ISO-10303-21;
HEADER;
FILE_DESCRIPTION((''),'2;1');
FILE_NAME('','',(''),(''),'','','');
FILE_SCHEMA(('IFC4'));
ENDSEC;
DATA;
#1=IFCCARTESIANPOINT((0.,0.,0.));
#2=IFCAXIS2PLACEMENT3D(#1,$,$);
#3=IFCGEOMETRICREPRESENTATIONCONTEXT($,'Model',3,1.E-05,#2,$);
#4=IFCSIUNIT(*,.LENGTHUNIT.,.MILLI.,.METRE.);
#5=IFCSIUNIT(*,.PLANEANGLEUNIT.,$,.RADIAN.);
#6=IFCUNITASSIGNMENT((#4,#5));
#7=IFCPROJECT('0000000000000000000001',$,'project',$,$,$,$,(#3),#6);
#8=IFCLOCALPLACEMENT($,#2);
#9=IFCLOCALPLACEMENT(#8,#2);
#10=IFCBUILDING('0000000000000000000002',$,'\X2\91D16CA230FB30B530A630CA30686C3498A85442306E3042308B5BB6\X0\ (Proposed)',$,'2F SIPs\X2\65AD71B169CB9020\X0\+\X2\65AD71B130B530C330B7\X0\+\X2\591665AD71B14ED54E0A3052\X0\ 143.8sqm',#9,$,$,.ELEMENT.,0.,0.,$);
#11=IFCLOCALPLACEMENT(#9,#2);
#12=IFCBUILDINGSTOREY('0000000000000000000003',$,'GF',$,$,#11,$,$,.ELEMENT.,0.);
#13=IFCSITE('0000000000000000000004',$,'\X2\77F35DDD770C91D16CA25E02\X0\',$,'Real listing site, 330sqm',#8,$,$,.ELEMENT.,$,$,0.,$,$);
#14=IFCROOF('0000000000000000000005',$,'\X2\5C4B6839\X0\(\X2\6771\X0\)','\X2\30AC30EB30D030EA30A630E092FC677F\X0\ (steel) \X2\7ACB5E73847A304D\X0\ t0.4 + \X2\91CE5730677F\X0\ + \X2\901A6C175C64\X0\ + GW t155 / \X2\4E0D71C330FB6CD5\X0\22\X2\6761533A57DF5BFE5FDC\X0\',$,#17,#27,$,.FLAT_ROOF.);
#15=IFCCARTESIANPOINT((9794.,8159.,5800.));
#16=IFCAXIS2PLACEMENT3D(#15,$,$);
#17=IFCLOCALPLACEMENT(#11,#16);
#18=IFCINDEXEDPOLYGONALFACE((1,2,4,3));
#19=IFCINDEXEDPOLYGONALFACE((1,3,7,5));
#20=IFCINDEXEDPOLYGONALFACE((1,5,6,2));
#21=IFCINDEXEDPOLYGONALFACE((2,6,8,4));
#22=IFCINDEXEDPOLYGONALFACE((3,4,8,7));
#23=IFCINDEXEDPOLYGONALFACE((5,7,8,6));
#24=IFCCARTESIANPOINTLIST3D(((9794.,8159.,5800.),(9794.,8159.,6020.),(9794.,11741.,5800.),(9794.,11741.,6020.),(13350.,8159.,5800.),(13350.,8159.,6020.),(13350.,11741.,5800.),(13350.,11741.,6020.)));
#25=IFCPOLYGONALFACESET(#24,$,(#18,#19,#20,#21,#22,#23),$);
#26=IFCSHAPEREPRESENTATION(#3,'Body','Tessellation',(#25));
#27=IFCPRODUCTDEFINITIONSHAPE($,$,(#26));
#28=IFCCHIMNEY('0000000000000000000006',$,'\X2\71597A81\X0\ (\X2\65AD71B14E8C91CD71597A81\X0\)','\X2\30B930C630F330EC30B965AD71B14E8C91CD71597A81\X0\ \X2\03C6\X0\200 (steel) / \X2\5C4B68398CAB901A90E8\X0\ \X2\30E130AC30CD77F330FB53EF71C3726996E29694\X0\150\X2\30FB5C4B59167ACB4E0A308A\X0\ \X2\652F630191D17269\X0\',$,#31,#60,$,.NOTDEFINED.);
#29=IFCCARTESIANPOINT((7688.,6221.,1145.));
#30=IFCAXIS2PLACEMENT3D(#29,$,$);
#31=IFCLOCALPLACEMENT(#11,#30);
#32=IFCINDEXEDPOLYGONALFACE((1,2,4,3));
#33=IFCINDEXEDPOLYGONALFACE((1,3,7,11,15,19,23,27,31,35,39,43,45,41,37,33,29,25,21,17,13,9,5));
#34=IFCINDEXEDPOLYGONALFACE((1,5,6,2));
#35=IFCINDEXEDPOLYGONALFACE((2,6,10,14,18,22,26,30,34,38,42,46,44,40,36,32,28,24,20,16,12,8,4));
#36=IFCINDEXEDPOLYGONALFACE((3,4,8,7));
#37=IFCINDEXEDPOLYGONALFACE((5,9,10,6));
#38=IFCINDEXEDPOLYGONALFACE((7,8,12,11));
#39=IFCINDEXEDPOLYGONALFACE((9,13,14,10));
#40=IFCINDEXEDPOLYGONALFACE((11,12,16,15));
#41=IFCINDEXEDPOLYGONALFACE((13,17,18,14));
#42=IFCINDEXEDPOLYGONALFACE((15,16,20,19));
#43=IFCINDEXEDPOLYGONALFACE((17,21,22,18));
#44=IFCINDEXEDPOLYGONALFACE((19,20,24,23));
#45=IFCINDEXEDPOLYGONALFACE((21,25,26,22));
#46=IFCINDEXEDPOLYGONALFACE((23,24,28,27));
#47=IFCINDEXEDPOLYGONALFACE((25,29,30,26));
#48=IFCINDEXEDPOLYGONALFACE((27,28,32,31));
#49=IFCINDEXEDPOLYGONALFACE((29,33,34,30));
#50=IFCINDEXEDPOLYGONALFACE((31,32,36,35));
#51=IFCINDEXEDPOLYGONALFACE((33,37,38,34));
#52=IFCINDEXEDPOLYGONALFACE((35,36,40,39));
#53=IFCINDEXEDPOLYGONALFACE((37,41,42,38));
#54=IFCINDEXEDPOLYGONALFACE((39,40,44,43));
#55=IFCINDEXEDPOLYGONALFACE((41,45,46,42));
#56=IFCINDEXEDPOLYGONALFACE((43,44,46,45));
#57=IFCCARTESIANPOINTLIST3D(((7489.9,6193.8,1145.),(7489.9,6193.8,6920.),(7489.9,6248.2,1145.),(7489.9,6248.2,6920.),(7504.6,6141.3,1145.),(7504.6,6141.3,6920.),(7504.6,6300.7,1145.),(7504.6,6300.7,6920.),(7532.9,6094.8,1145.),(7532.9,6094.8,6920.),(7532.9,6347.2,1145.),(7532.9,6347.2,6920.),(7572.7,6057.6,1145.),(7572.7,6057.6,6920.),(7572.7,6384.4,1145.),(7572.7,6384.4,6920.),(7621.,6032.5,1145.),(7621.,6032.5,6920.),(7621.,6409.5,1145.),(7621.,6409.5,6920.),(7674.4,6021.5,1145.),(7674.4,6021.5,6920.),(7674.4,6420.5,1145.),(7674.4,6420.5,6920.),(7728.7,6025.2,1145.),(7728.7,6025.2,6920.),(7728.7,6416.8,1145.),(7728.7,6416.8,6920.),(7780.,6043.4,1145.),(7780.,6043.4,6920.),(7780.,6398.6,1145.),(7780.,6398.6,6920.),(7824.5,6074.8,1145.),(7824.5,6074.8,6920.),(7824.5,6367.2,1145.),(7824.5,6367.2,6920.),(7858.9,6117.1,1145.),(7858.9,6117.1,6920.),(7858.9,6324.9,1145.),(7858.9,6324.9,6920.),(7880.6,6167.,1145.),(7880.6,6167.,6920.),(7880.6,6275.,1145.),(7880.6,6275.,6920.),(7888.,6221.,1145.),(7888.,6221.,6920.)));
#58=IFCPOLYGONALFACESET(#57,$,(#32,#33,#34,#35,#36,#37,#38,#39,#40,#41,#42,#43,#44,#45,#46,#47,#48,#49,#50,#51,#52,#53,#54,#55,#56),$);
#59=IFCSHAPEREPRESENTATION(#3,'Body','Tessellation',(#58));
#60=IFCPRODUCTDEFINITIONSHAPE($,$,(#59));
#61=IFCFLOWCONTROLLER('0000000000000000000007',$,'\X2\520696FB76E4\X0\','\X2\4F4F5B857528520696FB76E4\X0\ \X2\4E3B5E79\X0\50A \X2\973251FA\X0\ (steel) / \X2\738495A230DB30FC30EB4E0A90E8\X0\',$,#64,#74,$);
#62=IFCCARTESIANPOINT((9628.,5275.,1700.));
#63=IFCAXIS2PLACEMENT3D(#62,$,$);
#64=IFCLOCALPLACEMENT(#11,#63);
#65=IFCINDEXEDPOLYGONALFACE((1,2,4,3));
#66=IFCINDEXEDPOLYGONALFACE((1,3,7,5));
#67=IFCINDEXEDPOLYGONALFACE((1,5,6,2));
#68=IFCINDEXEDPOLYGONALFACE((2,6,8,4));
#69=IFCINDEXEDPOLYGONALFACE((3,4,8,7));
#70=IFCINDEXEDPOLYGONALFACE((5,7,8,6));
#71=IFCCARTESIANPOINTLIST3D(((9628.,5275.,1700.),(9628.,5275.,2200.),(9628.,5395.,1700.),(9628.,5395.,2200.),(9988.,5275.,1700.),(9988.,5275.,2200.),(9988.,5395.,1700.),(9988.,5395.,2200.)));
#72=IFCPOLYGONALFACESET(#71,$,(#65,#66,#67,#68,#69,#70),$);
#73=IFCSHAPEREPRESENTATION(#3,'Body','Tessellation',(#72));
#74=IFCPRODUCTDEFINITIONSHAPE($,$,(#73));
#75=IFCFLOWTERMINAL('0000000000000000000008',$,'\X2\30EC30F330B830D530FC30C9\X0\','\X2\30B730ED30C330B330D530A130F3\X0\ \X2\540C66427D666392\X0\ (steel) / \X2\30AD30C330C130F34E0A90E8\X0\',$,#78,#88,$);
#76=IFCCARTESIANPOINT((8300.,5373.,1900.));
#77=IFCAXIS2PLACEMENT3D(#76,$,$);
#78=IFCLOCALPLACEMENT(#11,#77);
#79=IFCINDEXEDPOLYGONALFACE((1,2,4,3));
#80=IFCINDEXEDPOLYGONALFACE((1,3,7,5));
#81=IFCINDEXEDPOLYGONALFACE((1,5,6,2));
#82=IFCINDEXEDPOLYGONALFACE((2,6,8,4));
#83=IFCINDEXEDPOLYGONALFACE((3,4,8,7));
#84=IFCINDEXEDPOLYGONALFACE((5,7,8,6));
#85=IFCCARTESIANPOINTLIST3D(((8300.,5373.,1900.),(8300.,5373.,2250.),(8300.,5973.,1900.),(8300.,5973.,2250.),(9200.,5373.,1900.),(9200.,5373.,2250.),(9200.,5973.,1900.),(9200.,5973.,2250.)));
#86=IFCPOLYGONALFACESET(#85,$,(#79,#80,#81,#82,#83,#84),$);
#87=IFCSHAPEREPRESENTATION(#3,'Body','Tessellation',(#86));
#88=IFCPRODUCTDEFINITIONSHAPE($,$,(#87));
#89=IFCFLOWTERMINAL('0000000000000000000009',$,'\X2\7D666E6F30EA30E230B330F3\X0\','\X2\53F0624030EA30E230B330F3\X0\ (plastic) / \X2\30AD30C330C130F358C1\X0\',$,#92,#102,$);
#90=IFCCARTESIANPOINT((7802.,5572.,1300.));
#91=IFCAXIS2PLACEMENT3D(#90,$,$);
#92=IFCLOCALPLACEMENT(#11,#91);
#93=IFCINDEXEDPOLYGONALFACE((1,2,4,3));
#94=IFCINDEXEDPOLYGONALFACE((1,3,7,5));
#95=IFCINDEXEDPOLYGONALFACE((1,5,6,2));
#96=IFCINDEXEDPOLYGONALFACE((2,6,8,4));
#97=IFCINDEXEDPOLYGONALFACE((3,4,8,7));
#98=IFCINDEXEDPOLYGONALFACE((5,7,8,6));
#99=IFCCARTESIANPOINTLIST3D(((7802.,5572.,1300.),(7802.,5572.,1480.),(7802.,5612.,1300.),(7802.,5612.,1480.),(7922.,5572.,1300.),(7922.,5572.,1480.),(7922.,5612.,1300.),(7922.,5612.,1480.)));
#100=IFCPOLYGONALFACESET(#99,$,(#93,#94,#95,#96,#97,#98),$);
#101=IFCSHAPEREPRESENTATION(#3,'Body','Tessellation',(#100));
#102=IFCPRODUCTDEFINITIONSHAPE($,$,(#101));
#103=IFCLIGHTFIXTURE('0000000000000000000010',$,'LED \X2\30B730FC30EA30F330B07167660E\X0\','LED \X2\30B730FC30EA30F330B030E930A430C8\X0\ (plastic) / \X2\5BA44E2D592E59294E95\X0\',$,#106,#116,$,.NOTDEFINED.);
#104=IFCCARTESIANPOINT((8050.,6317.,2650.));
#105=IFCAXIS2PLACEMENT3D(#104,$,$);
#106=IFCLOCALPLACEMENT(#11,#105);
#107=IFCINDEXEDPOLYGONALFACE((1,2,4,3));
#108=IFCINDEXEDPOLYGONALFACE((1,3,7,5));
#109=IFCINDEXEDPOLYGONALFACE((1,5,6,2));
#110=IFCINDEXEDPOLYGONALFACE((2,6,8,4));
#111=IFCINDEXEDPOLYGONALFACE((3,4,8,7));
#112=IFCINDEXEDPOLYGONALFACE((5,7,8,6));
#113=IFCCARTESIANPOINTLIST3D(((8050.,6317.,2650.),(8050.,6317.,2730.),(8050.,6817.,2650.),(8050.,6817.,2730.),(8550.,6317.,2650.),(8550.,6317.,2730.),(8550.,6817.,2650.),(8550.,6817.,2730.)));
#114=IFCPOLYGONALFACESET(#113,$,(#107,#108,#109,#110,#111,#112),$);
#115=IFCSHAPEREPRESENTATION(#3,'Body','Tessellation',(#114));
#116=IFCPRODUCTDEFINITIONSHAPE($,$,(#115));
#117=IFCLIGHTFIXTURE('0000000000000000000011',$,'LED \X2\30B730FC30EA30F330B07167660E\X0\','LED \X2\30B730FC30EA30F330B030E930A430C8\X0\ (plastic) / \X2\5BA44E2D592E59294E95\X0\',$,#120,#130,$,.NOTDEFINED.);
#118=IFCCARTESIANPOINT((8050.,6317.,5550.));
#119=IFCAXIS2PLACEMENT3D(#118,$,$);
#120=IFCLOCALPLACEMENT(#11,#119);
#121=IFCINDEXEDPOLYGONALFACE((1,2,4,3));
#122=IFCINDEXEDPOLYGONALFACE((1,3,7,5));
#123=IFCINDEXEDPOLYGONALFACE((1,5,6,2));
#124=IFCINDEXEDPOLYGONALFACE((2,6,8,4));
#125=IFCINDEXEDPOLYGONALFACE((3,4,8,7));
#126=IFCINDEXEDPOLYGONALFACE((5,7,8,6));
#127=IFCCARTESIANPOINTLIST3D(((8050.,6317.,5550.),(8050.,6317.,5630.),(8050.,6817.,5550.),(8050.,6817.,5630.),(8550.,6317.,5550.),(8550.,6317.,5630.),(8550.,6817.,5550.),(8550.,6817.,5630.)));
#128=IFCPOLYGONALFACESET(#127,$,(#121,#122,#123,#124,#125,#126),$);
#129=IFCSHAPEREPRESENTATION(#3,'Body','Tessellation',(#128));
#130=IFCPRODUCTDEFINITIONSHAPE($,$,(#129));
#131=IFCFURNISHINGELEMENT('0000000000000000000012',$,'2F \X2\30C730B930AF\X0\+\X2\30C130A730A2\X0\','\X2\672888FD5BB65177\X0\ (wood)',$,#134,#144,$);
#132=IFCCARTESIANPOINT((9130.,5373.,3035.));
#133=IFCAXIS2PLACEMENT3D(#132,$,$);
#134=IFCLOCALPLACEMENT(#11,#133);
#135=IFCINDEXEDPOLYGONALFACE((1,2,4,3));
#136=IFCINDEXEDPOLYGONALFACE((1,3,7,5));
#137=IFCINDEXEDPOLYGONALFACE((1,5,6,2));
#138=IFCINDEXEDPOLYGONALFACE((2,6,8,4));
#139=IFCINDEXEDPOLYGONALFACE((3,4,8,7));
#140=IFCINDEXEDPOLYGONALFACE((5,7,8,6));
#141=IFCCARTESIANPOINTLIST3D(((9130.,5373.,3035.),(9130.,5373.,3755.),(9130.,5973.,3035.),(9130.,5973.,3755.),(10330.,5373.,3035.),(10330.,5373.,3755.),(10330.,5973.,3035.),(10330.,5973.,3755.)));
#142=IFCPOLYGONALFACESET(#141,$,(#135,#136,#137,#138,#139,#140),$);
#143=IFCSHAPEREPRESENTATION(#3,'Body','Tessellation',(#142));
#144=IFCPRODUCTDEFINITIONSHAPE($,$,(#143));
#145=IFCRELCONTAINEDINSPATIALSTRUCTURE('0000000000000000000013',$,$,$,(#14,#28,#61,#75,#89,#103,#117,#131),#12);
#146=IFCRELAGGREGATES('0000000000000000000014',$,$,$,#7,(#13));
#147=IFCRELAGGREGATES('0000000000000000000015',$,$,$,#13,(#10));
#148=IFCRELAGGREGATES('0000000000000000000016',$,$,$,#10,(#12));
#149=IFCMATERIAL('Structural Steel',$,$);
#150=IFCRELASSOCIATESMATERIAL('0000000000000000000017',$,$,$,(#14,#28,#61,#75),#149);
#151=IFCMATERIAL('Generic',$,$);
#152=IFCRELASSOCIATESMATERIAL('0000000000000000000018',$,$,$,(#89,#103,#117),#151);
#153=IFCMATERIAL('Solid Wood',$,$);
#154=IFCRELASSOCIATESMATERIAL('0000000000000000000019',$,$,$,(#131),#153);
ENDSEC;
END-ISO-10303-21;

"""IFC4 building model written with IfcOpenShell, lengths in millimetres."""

from ifc_helpers import new_model, si_unit, frame, frame_2d, origin, origin_2d, place, context, project, spatial, rectangle, circle, extrude, material, element, save


model = new_model("IFC4")

# Units and contexts
model_context = context("Model", 3, precision=1e-05, world=origin())
ifc_project = project(units=[si_unit("LENGTHUNIT", "METRE", prefix="MILLI"), si_unit("PLANEANGLEUNIT", "RADIAN")], contexts=[model_context])

# Site, building, storey
site_placement = place(None, origin())
site = spatial("IfcSite", under=ifc_project, at=site_placement, Name="石川県金沢市", ObjectType="Real listing site, 330sqm", CompositionType="ELEMENT", RefElevation=0.0)
building_placement = place(site_placement, origin())
building = spatial("IfcBuilding", under=site, at=building_placement, Name="金沢・サウナと水風呂のある家 (Proposed)", ObjectType="2F SIPs断熱構造+断熱サッシ+外断熱仕上げ 143.8sqm", CompositionType="ELEMENT", ElevationOfRefHeight=0.0, ElevationOfTerrain=0.0)
storey_placement = place(building_placement, origin())
storey = spatial("IfcBuildingStorey", under=building, at=storey_placement, Name="GF", CompositionType="ELEMENT", Elevation=0.0)

# Shared definitions
ifc_material_1 = material(Name="Solid Wood")

# Roof
ifc_material_2 = material(Name="Structural Steel")
for number, where, name in (
    (1, (9794.0, 8159.0, 5800.0), "屋根(東)"),
):
    element("IfcRoof", number, at=place(storey_placement, frame(where)), inside=storey, material=ifc_material_2, Name=name, Description="ガルバリウム鋼板 (steel) 立平葺き t0.4 + 野地板 + 通気層 + GW t155 / 不燃・法22条区域対応", PredefinedType="FLAT_ROOF", context=model_context, shape_type="SweptSolid", body=[
        extrude(rectangle(XDim=3556.0, YDim=3582.0, at=frame_2d((1778.0, 1791.0))), frame((9794.0, 8159.0, 5800.0)), (0.0, 0.0, 1.0), 220.0),
    ])

# Chimney
chimney_placement = place(storey_placement, frame((7688.0, 6221.0, 1145.0)))
element("IfcChimney", 2, at=chimney_placement, inside=storey, material=ifc_material_2, Name="煙突 (断熱二重煙突)", Description="ステンレス断熱二重煙突 φ200 (steel) / 屋根貫通部 メガネ石・可燃物離隔150・屋外立上り 支持金物", PredefinedType="NOTDEFINED", context=model_context, shape_type="SweptSolid", body=[
    extrude(circle(Radius=200.0, at=origin_2d()), frame((7688.0, 6221.0, 1145.0)), (0.0, 0.0, 1.0), 5775.0),
])

# Flow controller
flow_controller_placement = place(storey_placement, frame((9628.0, 5275.0, 1700.0)))
element("IfcFlowController", 3, at=flow_controller_placement, inside=storey, material=ifc_material_2, Name="分電盤", Description="住宅用分電盤 主幹50A 露出 (steel) / 玄関ホール上部", context=model_context, shape_type="SweptSolid", body=[
    extrude(rectangle(XDim=360.0, YDim=120.0, at=frame_2d((180.0, 60.0))), frame((9628.0, 5275.0, 1700.0)), (0.0, 0.0, 1.0), 500.0),
])

# Flow terminals
flow_terminal_1_placement = place(storey_placement, frame((8300.0, 5373.0, 1900.0)))
element("IfcFlowTerminal", 4, at=flow_terminal_1_placement, inside=storey, material=ifc_material_2, Name="レンジフード", Description="シロッコファン 同時給排 (steel) / キッチン上部", context=model_context, shape_type="SweptSolid", body=[
    extrude(rectangle(XDim=900.0, YDim=600.0, at=frame_2d((450.0, 300.0))), frame((8300.0, 5373.0, 1900.0)), (0.0, 0.0, 1.0), 350.0),
])
ifc_material_3 = material(Name="Generic")
flow_terminal_2_placement = place(storey_placement, frame((7802.0, 5572.0, 1300.0)))
element("IfcFlowTerminal", 5, at=flow_terminal_2_placement, inside=storey, material=ifc_material_3, Name="給湯リモコン", Description="台所リモコン (plastic) / キッチン壁", context=model_context, shape_type="SweptSolid", body=[
    extrude(rectangle(XDim=120.0, YDim=40.0, at=frame_2d((60.0, 20.0))), frame((7802.0, 5572.0, 1300.0)), (0.0, 0.0, 1.0), 180.0),
])

# Light fixtures
light_fixture_1_placement = place(storey_placement, frame((8050.0, 6317.0, 2650.0)))
element("IfcLightFixture", 6, at=light_fixture_1_placement, inside=storey, material=ifc_material_3, Name="LED シーリング照明", Description="LED シーリングライト (plastic) / 室中央天井", PredefinedType="NOTDEFINED", context=model_context, shape_type="SweptSolid", body=[
    extrude(rectangle(XDim=500.0, YDim=500.0, at=frame_2d((250.0, 250.0))), frame((8050.0, 6317.0, 2650.0)), (0.0, 0.0, 1.0), 80.0),
])
light_fixture_2_placement = place(storey_placement, frame((8050.0, 6317.0, 5550.0)))
element("IfcLightFixture", 7, at=light_fixture_2_placement, inside=storey, material=ifc_material_3, Name="LED シーリング照明", Description="LED シーリングライト (plastic) / 室中央天井", PredefinedType="NOTDEFINED", context=model_context, shape_type="SweptSolid", body=[
    extrude(rectangle(XDim=500.0, YDim=500.0, at=frame_2d((250.0, 250.0))), frame((8050.0, 6317.0, 5550.0)), (0.0, 0.0, 1.0), 80.0),
])

# Furnishing element
furnishing_placement = place(storey_placement, frame((9130.0, 5373.0, 3035.0)))
element("IfcFurnishingElement", 8, at=furnishing_placement, inside=storey, material=ifc_material_1, Name="2F デスク+チェア", Description="木製家具 (wood)", context=model_context, shape_type="SweptSolid", body=[
    extrude(rectangle(XDim=1200.0, YDim=600.0, at=frame_2d((600.0, 300.0))), frame((9130.0, 5373.0, 3035.0)), (0.0, 0.0, 1.0), 720.0),
])

save(model, "model.ifc")
